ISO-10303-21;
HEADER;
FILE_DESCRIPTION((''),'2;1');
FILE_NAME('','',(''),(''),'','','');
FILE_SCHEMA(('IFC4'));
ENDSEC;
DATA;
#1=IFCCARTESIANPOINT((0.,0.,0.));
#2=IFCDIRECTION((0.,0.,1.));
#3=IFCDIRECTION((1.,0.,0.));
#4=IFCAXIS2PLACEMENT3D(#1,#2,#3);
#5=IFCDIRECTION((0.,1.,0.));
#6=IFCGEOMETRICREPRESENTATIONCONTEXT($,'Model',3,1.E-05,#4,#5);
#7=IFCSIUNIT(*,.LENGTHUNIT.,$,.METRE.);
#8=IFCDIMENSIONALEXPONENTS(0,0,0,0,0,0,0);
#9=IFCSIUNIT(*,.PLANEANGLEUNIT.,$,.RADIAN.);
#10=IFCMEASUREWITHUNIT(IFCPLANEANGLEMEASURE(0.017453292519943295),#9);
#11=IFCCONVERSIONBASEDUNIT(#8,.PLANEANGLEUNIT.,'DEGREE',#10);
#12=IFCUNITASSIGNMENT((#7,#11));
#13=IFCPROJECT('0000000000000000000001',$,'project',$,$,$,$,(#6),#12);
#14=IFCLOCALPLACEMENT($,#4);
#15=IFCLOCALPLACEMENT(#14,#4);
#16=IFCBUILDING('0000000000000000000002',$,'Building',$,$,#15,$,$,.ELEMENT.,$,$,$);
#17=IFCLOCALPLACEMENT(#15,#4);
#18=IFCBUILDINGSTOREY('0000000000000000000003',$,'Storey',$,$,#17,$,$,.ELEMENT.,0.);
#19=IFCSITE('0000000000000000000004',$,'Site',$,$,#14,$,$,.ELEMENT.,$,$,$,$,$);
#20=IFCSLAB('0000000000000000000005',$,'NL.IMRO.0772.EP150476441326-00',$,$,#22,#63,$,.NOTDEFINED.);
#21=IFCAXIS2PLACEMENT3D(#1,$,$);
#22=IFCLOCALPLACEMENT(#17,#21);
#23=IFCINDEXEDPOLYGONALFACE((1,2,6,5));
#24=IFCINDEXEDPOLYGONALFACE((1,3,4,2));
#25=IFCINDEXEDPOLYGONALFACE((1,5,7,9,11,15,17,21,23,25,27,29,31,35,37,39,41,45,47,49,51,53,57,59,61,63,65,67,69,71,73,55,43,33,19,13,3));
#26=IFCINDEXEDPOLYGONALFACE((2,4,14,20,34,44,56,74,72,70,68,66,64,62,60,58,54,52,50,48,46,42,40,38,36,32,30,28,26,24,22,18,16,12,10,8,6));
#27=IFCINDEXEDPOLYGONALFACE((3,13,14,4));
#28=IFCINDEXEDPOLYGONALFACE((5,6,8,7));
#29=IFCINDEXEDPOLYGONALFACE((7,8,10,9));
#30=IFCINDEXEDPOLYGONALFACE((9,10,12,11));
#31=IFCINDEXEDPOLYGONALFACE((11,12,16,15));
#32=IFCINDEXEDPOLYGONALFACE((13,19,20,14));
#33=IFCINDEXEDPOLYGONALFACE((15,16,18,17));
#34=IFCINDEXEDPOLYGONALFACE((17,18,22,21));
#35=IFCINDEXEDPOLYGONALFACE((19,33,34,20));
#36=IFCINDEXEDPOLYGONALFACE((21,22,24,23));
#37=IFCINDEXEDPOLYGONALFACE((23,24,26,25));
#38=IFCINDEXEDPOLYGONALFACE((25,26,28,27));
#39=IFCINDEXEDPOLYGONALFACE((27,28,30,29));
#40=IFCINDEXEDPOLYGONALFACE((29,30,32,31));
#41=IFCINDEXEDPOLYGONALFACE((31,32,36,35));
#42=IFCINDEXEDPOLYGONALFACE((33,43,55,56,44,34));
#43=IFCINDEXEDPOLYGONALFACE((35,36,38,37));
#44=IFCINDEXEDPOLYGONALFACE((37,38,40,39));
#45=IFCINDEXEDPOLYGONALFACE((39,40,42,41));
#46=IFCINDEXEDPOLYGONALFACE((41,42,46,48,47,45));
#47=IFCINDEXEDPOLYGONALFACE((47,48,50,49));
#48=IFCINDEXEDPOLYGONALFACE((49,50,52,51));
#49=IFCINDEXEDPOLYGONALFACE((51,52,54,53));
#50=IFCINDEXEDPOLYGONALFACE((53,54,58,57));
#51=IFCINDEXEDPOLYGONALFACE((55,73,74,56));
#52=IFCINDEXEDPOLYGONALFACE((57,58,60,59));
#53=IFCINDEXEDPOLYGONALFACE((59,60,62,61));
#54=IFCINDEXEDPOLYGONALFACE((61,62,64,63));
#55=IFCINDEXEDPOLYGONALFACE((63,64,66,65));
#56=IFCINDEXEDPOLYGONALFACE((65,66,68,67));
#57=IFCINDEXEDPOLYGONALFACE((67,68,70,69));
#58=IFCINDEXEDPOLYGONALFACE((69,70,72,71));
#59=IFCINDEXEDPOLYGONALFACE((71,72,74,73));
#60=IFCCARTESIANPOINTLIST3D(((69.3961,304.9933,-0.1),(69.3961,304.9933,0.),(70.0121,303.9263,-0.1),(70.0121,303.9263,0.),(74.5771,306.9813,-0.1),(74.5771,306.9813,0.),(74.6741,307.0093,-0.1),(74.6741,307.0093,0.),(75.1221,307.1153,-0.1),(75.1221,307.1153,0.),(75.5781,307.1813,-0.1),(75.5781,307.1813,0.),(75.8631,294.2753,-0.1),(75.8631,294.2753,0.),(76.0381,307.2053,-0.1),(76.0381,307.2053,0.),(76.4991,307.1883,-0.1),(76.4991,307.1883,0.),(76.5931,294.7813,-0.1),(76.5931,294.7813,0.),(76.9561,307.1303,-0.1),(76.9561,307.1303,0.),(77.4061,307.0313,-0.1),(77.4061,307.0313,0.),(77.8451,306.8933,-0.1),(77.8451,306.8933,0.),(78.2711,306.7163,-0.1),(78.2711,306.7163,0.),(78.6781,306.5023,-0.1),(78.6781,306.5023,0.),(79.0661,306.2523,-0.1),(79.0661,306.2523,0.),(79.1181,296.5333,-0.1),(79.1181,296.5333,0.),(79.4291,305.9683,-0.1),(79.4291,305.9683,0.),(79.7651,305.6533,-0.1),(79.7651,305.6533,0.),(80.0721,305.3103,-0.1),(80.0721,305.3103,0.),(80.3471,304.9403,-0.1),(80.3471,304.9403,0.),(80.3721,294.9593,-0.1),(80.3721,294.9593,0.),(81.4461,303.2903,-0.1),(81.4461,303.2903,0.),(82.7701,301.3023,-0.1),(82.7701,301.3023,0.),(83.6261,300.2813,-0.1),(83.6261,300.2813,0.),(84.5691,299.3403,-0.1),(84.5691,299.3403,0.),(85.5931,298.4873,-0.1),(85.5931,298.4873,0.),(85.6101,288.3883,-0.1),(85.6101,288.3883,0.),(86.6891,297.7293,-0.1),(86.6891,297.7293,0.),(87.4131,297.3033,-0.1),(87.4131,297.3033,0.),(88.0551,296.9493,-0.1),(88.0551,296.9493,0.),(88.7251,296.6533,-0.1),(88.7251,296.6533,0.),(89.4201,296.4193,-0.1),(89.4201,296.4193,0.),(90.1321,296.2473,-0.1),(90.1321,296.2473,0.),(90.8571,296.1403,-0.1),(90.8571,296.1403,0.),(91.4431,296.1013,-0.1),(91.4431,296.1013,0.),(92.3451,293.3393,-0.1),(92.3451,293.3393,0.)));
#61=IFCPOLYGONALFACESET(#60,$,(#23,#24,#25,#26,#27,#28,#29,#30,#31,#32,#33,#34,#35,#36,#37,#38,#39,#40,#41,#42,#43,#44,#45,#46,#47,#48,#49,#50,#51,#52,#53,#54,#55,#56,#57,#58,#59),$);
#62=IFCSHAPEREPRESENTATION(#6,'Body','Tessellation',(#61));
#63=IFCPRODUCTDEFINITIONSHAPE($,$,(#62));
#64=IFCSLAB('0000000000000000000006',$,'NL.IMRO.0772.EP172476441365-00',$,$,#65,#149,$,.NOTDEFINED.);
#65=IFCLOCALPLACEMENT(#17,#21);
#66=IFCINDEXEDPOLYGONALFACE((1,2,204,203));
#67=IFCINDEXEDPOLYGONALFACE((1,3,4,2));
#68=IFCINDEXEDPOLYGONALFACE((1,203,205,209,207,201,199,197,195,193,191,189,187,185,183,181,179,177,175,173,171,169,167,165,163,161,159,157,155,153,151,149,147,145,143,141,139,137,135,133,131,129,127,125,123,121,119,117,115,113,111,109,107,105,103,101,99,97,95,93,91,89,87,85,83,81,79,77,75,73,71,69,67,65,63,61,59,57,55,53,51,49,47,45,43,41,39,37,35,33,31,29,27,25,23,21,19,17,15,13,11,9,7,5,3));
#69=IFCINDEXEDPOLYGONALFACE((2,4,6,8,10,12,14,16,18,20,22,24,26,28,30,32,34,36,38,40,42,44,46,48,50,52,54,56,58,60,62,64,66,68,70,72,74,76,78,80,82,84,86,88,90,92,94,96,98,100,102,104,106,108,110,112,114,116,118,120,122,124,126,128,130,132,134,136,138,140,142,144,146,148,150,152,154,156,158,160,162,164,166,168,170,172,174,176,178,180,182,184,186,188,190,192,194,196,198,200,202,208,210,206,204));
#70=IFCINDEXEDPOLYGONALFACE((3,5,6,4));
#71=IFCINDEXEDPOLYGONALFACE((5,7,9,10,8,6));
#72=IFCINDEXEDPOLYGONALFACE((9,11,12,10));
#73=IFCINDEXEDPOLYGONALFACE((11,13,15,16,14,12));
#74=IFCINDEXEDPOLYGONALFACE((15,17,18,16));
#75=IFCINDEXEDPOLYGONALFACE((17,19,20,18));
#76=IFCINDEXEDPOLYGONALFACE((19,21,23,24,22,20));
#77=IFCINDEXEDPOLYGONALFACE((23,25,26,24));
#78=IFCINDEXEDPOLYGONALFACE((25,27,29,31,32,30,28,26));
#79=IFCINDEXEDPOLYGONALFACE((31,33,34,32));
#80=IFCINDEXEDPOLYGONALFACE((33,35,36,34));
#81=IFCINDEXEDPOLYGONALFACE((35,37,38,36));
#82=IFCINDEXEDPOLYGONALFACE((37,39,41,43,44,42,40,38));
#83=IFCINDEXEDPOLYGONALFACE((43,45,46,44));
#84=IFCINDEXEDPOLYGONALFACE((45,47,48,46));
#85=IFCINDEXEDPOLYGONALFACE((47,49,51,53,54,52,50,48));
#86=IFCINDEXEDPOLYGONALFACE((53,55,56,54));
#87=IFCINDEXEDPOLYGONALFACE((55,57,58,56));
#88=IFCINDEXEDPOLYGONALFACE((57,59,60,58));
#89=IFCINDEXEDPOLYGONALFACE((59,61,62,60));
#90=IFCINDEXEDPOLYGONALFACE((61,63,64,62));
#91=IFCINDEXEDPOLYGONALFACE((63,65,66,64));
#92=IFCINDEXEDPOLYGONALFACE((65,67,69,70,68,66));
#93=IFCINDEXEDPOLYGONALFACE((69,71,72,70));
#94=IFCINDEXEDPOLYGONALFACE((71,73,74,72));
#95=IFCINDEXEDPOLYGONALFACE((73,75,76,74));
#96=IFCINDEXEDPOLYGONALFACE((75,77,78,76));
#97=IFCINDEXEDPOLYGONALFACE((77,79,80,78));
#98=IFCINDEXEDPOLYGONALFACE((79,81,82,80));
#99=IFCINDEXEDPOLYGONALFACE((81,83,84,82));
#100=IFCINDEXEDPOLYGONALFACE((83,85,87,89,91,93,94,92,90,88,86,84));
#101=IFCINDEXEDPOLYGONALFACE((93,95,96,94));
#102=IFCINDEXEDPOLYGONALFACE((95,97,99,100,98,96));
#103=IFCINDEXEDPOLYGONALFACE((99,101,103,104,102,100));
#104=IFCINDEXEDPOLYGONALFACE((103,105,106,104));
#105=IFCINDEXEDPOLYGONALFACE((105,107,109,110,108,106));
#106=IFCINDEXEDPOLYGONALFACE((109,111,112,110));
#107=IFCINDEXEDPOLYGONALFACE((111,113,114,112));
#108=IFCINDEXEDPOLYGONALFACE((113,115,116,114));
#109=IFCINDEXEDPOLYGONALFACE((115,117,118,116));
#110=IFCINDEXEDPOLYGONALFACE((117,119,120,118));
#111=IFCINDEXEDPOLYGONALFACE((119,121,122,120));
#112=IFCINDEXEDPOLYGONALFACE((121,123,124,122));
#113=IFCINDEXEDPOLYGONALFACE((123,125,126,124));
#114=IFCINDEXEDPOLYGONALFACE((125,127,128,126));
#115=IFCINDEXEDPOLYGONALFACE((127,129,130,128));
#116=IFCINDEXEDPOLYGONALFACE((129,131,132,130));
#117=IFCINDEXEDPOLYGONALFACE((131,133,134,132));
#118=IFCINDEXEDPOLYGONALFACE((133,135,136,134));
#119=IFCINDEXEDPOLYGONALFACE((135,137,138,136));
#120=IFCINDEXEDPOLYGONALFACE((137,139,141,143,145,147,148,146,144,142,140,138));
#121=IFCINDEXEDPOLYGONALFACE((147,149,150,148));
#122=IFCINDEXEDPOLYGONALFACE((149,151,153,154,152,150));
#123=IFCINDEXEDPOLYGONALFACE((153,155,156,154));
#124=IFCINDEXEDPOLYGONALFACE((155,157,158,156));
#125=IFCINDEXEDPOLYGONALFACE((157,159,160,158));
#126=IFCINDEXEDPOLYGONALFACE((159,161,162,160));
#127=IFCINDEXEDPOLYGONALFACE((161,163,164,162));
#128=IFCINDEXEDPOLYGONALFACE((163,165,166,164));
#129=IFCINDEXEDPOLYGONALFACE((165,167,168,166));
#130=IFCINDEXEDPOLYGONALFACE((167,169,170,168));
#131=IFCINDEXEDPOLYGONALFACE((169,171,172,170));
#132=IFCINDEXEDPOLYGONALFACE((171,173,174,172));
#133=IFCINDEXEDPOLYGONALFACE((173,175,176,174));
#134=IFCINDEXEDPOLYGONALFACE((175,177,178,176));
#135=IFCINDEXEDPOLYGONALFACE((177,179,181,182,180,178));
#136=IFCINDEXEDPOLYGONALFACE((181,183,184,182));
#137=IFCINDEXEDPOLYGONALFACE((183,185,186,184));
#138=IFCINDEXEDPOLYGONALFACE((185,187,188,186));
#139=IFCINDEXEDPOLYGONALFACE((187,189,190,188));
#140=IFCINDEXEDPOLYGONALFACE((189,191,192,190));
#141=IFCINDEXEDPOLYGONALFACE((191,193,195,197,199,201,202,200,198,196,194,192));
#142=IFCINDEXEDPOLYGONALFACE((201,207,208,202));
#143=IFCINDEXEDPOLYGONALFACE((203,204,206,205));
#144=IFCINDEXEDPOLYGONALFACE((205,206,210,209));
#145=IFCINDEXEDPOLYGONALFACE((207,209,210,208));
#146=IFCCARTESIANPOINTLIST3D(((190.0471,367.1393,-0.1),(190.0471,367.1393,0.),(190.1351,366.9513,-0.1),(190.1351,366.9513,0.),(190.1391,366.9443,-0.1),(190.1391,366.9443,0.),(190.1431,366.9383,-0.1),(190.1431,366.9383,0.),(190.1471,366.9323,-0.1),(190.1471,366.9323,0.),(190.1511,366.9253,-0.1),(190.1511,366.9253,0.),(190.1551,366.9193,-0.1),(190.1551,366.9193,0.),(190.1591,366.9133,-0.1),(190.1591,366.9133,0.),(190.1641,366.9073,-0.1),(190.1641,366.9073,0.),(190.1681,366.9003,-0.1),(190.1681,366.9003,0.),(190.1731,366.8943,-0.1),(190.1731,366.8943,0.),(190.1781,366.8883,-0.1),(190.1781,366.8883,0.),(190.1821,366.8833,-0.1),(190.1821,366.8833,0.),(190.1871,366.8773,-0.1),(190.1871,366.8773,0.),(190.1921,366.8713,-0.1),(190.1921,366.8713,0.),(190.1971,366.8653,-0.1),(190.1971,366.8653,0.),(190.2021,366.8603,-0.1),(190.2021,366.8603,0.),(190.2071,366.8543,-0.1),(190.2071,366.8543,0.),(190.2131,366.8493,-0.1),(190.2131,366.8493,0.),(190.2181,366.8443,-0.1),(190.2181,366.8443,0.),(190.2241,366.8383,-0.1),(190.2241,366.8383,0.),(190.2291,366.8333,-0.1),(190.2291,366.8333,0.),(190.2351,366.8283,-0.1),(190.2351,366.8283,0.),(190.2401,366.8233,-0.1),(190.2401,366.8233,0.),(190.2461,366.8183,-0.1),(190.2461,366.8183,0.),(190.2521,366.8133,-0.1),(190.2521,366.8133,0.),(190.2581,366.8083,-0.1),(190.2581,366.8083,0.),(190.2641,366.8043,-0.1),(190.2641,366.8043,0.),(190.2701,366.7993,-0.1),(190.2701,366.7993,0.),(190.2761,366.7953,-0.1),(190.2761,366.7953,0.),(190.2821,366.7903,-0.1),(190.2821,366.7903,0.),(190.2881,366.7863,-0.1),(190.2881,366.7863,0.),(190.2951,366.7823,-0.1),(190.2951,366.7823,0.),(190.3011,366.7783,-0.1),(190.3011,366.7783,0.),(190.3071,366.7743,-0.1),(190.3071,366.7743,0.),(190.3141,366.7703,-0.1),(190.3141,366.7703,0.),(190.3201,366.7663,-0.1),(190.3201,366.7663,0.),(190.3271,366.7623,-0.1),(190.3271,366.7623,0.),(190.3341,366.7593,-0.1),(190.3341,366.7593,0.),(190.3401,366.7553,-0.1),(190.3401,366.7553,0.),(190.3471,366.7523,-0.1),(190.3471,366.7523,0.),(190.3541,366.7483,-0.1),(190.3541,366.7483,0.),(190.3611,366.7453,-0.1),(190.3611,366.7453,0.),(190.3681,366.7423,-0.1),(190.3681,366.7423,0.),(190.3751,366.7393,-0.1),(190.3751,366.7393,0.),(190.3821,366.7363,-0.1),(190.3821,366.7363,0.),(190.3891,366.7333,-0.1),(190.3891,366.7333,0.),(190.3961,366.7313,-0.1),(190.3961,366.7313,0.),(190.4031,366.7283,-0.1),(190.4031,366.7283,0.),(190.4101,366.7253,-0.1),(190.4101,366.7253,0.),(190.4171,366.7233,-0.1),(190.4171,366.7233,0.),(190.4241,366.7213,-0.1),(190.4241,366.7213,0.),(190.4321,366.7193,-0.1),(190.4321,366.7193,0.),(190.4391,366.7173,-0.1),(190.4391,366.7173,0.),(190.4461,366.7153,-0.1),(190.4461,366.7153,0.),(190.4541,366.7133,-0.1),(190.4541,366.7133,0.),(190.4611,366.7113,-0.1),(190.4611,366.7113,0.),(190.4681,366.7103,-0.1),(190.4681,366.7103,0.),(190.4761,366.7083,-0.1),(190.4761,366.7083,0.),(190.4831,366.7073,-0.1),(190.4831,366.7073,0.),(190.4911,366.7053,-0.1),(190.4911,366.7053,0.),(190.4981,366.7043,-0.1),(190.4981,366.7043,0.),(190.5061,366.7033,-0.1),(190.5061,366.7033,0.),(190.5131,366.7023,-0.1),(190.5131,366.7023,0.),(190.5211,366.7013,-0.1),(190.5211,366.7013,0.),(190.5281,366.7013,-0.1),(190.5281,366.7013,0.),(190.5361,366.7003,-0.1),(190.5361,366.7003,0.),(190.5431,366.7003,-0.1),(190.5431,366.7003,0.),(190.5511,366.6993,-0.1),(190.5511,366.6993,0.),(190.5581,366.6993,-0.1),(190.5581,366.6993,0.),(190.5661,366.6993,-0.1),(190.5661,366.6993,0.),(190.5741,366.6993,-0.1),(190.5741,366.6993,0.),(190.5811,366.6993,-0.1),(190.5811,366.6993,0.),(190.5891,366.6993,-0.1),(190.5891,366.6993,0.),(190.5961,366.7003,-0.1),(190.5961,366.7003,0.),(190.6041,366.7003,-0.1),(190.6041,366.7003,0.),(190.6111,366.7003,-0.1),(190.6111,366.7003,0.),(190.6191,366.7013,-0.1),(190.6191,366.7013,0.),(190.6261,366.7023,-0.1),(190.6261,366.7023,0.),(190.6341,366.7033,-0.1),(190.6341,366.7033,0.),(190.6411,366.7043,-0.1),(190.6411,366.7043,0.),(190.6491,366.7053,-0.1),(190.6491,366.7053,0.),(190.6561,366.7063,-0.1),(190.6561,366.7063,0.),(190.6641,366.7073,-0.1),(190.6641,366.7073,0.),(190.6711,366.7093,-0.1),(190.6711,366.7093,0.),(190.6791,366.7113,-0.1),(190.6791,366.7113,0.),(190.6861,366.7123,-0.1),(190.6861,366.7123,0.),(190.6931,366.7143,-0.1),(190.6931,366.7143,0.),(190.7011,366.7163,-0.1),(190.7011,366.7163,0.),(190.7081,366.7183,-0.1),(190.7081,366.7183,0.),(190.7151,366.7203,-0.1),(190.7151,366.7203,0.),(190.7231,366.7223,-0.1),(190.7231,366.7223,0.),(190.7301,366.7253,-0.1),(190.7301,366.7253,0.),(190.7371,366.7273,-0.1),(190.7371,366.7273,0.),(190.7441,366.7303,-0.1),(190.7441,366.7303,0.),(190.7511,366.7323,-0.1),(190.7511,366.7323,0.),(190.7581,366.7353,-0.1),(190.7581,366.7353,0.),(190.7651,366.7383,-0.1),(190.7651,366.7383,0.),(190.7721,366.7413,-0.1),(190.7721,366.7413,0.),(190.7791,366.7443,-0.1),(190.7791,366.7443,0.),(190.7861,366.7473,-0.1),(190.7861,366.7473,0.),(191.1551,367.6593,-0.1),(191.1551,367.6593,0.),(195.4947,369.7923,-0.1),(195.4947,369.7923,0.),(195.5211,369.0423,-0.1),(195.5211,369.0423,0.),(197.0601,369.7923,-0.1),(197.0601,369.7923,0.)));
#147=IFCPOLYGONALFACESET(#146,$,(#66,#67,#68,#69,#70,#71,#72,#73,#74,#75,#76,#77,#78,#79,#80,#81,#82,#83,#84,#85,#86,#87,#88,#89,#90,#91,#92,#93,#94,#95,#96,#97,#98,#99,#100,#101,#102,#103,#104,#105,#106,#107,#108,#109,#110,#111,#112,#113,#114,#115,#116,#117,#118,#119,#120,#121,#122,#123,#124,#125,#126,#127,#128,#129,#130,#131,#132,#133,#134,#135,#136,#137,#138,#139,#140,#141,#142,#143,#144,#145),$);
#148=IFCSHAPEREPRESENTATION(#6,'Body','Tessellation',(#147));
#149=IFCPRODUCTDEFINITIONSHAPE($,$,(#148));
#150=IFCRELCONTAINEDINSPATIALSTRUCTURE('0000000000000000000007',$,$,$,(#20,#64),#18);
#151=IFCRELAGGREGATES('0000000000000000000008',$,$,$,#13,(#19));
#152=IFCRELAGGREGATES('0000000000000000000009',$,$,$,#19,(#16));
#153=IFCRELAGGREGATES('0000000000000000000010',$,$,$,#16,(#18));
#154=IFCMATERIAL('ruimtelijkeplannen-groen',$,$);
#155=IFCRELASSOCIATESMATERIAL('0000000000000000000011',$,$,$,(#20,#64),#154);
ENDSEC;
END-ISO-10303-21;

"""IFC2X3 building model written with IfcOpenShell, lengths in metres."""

from ifc_helpers import new_model, entity, si_unit, converted_unit, direction, frame, origin_with_axes, place, context, project, spatial, polyline, outline, extrude, material, element, save


model = new_model("IFC2X3")

# Units and contexts
model_context = context("Model", 3, precision=1e-05, world=origin_with_axes(), true_north=direction((0.0, 1.0, 0.0)))
ifc_project = project(units=[si_unit("LENGTHUNIT", "METRE"), converted_unit("PLANEANGLEUNIT", "DEGREE", entity("IfcPlaneAngleMeasure", 0.017453292519943295), si_unit("PLANEANGLEUNIT", "RADIAN"), dimensions=[0, 0, 0, 0, 0, 0, 0])], contexts=[model_context])

# Site, building, storey
site_placement = place(None, origin_with_axes())
site = spatial("IfcSite", under=ifc_project, at=site_placement, Name="Site", CompositionType="ELEMENT")
building_placement = place(site_placement, origin_with_axes())
building = spatial("IfcBuilding", under=site, at=building_placement, Name="Building", CompositionType="ELEMENT")
storey_placement = place(building_placement, origin_with_axes())
storey = spatial("IfcBuildingStorey", under=building, at=storey_placement, Name="Storey", CompositionType="ELEMENT", Elevation=0.0)

# Slabs
ifc_material_1 = material(Name="ruimtelijkeplannen-groen")
slab_1_placement = place(storey_placement, frame((0.0, 0.0, -0.1), z_axis=(0.0, 0.0, 1.0), x_axis=(1.0, 0.0, 0.0)))
element("IfcSlab", 1, at=slab_1_placement, inside=storey, material=ifc_material_1, Name="NL.IMRO.0772.EP150476441326-00", PredefinedType="NOTDEFINED", context=model_context, shape_type="SweptSolid", body=[
    extrude(outline(polyline([(85.6101, 288.3883), (80.3721, 294.9593), (79.1181, 296.5333), (76.5931, 294.7813), (75.8631, 294.2753), (70.0121, 303.9263), (69.3961, 304.9933), (74.5771, 306.9813), (74.6741, 307.0093), (75.1221, 307.1153), (75.5781, 307.1813), (76.0381, 307.2053), (76.4991, 307.1883), (76.9561, 307.1303), (77.4061, 307.0313), (77.8451, 306.8933), (78.2711, 306.7163), (78.6781, 306.5023), (79.0661, 306.2523), (79.4291, 305.9683), (79.7651, 305.6533), (80.0721, 305.3103), (80.3471, 304.9403), (81.4461, 303.2903), (82.7701, 301.3023), (83.6261, 300.2813), (84.5691, 299.3403), (85.5931, 298.4873), (86.6891, 297.7293), (87.4131, 297.3033), (88.0551, 296.9493), (88.7251, 296.6533), (89.4201, 296.4193), (90.1321, 296.2473), (90.8571, 296.1403), (91.4431, 296.1013), (92.3451, 293.3393), (85.6101, 288.3883)])), origin_with_axes(), (0.0, 0.0, 1.0), 0.1),
])
slab_2_placement = place(storey_placement, frame((0.0, 0.0, -0.1), z_axis=(0.0, 0.0, 1.0), x_axis=(1.0, 0.0, 0.0)))
element("IfcSlab", 2, at=slab_2_placement, inside=storey, material=ifc_material_1, Name="NL.IMRO.0772.EP172476441365-00", PredefinedType="NOTDEFINED", context=model_context, shape_type="SweptSolid", body=[
    extrude(outline(polyline([(195.5211, 369.0423), (190.7861, 366.7473), (190.7791, 366.7443), (190.7721, 366.7413), (190.7651, 366.7383), (190.7581, 366.7353), (190.7511, 366.7323), (190.7441, 366.7303), (190.7371, 366.7273), (190.7301, 366.7253), (190.7231, 366.7223), (190.7151, 366.7203), (190.7081, 366.7183), (190.7011, 366.7163), (190.6931, 366.7143), (190.6861, 366.7123), (190.6791, 366.7113), (190.6711, 366.7093), (190.6641, 366.7073), (190.6561, 366.7063), (190.6491, 366.7053), (190.6411, 366.7043), (190.6341, 366.7033), (190.6261, 366.7023), (190.6191, 366.7013), (190.6111, 366.7003), (190.6041, 366.7003), (190.5961, 366.7003), (190.5891, 366.6993), (190.5811, 366.6993), (190.5741, 366.6993), (190.5661, 366.6993), (190.5581, 366.6993), (190.5511, 366.6993), (190.5431, 366.7003), (190.5361, 366.7003), (190.5281, 366.7013), (190.5211, 366.7013), (190.5131, 366.7023), (190.5061, 366.7033), (190.4981, 366.7043), (190.4911, 366.7053), (190.4831, 366.7073), (190.4761, 366.7083), (190.4681, 366.7103), (190.4611, 366.7113), (190.4541, 366.7133), (190.4461, 366.7153), (190.4391, 366.7173), (190.4321, 366.7193), (190.4241, 366.7213), (190.4171, 366.7233), (190.4101, 366.7253), (190.4031, 366.7283), (190.3961, 366.7313), (190.3891, 366.7333), (190.3821, 366.7363), (190.3751, 366.7393), (190.3681, 366.7423), (190.3611, 366.7453), (190.3541, 366.7483), (190.3471, 366.7523), (190.3401, 366.7553), (190.3341, 366.7593), (190.3271, 366.7623), (190.3201, 366.7663), (190.3141, 366.7703), (190.3071, 366.7743), (190.3011, 366.7783), (190.2951, 366.7823), (190.2881, 366.7863), (190.2821, 366.7903), (190.2761, 366.7953), (190.2701, 366.7993), (190.2641, 366.8043), (190.2581, 366.8083), (190.2521, 366.8133), (190.2461, 366.8183), (190.2401, 366.8233), (190.2351, 366.8283), (190.2291, 366.8333), (190.2241, 366.8383), (190.2181, 366.8443), (190.2131, 366.8493), (190.2071, 366.8543), (190.2021, 366.8603), (190.1971, 366.8653), (190.1921, 366.8713), (190.1871, 366.8773), (190.1821, 366.8833), (190.1781, 366.8883), (190.1731, 366.8943), (190.1681, 366.9003), (190.1641, 366.9073), (190.1591, 366.9133), (190.1551, 366.9193), (190.1511, 366.9253), (190.1471, 366.9323), (190.1431, 366.9383), (190.1391, 366.9443), (190.1351, 366.9513), (190.0471, 367.1393), (191.1551, 367.6593), (195.4947, 369.7923), (197.0601, 369.7923), (195.5211, 369.0423)])), origin_with_axes(), (0.0, 0.0, 1.0), 0.1),
])

save(model, "model.ifc")
